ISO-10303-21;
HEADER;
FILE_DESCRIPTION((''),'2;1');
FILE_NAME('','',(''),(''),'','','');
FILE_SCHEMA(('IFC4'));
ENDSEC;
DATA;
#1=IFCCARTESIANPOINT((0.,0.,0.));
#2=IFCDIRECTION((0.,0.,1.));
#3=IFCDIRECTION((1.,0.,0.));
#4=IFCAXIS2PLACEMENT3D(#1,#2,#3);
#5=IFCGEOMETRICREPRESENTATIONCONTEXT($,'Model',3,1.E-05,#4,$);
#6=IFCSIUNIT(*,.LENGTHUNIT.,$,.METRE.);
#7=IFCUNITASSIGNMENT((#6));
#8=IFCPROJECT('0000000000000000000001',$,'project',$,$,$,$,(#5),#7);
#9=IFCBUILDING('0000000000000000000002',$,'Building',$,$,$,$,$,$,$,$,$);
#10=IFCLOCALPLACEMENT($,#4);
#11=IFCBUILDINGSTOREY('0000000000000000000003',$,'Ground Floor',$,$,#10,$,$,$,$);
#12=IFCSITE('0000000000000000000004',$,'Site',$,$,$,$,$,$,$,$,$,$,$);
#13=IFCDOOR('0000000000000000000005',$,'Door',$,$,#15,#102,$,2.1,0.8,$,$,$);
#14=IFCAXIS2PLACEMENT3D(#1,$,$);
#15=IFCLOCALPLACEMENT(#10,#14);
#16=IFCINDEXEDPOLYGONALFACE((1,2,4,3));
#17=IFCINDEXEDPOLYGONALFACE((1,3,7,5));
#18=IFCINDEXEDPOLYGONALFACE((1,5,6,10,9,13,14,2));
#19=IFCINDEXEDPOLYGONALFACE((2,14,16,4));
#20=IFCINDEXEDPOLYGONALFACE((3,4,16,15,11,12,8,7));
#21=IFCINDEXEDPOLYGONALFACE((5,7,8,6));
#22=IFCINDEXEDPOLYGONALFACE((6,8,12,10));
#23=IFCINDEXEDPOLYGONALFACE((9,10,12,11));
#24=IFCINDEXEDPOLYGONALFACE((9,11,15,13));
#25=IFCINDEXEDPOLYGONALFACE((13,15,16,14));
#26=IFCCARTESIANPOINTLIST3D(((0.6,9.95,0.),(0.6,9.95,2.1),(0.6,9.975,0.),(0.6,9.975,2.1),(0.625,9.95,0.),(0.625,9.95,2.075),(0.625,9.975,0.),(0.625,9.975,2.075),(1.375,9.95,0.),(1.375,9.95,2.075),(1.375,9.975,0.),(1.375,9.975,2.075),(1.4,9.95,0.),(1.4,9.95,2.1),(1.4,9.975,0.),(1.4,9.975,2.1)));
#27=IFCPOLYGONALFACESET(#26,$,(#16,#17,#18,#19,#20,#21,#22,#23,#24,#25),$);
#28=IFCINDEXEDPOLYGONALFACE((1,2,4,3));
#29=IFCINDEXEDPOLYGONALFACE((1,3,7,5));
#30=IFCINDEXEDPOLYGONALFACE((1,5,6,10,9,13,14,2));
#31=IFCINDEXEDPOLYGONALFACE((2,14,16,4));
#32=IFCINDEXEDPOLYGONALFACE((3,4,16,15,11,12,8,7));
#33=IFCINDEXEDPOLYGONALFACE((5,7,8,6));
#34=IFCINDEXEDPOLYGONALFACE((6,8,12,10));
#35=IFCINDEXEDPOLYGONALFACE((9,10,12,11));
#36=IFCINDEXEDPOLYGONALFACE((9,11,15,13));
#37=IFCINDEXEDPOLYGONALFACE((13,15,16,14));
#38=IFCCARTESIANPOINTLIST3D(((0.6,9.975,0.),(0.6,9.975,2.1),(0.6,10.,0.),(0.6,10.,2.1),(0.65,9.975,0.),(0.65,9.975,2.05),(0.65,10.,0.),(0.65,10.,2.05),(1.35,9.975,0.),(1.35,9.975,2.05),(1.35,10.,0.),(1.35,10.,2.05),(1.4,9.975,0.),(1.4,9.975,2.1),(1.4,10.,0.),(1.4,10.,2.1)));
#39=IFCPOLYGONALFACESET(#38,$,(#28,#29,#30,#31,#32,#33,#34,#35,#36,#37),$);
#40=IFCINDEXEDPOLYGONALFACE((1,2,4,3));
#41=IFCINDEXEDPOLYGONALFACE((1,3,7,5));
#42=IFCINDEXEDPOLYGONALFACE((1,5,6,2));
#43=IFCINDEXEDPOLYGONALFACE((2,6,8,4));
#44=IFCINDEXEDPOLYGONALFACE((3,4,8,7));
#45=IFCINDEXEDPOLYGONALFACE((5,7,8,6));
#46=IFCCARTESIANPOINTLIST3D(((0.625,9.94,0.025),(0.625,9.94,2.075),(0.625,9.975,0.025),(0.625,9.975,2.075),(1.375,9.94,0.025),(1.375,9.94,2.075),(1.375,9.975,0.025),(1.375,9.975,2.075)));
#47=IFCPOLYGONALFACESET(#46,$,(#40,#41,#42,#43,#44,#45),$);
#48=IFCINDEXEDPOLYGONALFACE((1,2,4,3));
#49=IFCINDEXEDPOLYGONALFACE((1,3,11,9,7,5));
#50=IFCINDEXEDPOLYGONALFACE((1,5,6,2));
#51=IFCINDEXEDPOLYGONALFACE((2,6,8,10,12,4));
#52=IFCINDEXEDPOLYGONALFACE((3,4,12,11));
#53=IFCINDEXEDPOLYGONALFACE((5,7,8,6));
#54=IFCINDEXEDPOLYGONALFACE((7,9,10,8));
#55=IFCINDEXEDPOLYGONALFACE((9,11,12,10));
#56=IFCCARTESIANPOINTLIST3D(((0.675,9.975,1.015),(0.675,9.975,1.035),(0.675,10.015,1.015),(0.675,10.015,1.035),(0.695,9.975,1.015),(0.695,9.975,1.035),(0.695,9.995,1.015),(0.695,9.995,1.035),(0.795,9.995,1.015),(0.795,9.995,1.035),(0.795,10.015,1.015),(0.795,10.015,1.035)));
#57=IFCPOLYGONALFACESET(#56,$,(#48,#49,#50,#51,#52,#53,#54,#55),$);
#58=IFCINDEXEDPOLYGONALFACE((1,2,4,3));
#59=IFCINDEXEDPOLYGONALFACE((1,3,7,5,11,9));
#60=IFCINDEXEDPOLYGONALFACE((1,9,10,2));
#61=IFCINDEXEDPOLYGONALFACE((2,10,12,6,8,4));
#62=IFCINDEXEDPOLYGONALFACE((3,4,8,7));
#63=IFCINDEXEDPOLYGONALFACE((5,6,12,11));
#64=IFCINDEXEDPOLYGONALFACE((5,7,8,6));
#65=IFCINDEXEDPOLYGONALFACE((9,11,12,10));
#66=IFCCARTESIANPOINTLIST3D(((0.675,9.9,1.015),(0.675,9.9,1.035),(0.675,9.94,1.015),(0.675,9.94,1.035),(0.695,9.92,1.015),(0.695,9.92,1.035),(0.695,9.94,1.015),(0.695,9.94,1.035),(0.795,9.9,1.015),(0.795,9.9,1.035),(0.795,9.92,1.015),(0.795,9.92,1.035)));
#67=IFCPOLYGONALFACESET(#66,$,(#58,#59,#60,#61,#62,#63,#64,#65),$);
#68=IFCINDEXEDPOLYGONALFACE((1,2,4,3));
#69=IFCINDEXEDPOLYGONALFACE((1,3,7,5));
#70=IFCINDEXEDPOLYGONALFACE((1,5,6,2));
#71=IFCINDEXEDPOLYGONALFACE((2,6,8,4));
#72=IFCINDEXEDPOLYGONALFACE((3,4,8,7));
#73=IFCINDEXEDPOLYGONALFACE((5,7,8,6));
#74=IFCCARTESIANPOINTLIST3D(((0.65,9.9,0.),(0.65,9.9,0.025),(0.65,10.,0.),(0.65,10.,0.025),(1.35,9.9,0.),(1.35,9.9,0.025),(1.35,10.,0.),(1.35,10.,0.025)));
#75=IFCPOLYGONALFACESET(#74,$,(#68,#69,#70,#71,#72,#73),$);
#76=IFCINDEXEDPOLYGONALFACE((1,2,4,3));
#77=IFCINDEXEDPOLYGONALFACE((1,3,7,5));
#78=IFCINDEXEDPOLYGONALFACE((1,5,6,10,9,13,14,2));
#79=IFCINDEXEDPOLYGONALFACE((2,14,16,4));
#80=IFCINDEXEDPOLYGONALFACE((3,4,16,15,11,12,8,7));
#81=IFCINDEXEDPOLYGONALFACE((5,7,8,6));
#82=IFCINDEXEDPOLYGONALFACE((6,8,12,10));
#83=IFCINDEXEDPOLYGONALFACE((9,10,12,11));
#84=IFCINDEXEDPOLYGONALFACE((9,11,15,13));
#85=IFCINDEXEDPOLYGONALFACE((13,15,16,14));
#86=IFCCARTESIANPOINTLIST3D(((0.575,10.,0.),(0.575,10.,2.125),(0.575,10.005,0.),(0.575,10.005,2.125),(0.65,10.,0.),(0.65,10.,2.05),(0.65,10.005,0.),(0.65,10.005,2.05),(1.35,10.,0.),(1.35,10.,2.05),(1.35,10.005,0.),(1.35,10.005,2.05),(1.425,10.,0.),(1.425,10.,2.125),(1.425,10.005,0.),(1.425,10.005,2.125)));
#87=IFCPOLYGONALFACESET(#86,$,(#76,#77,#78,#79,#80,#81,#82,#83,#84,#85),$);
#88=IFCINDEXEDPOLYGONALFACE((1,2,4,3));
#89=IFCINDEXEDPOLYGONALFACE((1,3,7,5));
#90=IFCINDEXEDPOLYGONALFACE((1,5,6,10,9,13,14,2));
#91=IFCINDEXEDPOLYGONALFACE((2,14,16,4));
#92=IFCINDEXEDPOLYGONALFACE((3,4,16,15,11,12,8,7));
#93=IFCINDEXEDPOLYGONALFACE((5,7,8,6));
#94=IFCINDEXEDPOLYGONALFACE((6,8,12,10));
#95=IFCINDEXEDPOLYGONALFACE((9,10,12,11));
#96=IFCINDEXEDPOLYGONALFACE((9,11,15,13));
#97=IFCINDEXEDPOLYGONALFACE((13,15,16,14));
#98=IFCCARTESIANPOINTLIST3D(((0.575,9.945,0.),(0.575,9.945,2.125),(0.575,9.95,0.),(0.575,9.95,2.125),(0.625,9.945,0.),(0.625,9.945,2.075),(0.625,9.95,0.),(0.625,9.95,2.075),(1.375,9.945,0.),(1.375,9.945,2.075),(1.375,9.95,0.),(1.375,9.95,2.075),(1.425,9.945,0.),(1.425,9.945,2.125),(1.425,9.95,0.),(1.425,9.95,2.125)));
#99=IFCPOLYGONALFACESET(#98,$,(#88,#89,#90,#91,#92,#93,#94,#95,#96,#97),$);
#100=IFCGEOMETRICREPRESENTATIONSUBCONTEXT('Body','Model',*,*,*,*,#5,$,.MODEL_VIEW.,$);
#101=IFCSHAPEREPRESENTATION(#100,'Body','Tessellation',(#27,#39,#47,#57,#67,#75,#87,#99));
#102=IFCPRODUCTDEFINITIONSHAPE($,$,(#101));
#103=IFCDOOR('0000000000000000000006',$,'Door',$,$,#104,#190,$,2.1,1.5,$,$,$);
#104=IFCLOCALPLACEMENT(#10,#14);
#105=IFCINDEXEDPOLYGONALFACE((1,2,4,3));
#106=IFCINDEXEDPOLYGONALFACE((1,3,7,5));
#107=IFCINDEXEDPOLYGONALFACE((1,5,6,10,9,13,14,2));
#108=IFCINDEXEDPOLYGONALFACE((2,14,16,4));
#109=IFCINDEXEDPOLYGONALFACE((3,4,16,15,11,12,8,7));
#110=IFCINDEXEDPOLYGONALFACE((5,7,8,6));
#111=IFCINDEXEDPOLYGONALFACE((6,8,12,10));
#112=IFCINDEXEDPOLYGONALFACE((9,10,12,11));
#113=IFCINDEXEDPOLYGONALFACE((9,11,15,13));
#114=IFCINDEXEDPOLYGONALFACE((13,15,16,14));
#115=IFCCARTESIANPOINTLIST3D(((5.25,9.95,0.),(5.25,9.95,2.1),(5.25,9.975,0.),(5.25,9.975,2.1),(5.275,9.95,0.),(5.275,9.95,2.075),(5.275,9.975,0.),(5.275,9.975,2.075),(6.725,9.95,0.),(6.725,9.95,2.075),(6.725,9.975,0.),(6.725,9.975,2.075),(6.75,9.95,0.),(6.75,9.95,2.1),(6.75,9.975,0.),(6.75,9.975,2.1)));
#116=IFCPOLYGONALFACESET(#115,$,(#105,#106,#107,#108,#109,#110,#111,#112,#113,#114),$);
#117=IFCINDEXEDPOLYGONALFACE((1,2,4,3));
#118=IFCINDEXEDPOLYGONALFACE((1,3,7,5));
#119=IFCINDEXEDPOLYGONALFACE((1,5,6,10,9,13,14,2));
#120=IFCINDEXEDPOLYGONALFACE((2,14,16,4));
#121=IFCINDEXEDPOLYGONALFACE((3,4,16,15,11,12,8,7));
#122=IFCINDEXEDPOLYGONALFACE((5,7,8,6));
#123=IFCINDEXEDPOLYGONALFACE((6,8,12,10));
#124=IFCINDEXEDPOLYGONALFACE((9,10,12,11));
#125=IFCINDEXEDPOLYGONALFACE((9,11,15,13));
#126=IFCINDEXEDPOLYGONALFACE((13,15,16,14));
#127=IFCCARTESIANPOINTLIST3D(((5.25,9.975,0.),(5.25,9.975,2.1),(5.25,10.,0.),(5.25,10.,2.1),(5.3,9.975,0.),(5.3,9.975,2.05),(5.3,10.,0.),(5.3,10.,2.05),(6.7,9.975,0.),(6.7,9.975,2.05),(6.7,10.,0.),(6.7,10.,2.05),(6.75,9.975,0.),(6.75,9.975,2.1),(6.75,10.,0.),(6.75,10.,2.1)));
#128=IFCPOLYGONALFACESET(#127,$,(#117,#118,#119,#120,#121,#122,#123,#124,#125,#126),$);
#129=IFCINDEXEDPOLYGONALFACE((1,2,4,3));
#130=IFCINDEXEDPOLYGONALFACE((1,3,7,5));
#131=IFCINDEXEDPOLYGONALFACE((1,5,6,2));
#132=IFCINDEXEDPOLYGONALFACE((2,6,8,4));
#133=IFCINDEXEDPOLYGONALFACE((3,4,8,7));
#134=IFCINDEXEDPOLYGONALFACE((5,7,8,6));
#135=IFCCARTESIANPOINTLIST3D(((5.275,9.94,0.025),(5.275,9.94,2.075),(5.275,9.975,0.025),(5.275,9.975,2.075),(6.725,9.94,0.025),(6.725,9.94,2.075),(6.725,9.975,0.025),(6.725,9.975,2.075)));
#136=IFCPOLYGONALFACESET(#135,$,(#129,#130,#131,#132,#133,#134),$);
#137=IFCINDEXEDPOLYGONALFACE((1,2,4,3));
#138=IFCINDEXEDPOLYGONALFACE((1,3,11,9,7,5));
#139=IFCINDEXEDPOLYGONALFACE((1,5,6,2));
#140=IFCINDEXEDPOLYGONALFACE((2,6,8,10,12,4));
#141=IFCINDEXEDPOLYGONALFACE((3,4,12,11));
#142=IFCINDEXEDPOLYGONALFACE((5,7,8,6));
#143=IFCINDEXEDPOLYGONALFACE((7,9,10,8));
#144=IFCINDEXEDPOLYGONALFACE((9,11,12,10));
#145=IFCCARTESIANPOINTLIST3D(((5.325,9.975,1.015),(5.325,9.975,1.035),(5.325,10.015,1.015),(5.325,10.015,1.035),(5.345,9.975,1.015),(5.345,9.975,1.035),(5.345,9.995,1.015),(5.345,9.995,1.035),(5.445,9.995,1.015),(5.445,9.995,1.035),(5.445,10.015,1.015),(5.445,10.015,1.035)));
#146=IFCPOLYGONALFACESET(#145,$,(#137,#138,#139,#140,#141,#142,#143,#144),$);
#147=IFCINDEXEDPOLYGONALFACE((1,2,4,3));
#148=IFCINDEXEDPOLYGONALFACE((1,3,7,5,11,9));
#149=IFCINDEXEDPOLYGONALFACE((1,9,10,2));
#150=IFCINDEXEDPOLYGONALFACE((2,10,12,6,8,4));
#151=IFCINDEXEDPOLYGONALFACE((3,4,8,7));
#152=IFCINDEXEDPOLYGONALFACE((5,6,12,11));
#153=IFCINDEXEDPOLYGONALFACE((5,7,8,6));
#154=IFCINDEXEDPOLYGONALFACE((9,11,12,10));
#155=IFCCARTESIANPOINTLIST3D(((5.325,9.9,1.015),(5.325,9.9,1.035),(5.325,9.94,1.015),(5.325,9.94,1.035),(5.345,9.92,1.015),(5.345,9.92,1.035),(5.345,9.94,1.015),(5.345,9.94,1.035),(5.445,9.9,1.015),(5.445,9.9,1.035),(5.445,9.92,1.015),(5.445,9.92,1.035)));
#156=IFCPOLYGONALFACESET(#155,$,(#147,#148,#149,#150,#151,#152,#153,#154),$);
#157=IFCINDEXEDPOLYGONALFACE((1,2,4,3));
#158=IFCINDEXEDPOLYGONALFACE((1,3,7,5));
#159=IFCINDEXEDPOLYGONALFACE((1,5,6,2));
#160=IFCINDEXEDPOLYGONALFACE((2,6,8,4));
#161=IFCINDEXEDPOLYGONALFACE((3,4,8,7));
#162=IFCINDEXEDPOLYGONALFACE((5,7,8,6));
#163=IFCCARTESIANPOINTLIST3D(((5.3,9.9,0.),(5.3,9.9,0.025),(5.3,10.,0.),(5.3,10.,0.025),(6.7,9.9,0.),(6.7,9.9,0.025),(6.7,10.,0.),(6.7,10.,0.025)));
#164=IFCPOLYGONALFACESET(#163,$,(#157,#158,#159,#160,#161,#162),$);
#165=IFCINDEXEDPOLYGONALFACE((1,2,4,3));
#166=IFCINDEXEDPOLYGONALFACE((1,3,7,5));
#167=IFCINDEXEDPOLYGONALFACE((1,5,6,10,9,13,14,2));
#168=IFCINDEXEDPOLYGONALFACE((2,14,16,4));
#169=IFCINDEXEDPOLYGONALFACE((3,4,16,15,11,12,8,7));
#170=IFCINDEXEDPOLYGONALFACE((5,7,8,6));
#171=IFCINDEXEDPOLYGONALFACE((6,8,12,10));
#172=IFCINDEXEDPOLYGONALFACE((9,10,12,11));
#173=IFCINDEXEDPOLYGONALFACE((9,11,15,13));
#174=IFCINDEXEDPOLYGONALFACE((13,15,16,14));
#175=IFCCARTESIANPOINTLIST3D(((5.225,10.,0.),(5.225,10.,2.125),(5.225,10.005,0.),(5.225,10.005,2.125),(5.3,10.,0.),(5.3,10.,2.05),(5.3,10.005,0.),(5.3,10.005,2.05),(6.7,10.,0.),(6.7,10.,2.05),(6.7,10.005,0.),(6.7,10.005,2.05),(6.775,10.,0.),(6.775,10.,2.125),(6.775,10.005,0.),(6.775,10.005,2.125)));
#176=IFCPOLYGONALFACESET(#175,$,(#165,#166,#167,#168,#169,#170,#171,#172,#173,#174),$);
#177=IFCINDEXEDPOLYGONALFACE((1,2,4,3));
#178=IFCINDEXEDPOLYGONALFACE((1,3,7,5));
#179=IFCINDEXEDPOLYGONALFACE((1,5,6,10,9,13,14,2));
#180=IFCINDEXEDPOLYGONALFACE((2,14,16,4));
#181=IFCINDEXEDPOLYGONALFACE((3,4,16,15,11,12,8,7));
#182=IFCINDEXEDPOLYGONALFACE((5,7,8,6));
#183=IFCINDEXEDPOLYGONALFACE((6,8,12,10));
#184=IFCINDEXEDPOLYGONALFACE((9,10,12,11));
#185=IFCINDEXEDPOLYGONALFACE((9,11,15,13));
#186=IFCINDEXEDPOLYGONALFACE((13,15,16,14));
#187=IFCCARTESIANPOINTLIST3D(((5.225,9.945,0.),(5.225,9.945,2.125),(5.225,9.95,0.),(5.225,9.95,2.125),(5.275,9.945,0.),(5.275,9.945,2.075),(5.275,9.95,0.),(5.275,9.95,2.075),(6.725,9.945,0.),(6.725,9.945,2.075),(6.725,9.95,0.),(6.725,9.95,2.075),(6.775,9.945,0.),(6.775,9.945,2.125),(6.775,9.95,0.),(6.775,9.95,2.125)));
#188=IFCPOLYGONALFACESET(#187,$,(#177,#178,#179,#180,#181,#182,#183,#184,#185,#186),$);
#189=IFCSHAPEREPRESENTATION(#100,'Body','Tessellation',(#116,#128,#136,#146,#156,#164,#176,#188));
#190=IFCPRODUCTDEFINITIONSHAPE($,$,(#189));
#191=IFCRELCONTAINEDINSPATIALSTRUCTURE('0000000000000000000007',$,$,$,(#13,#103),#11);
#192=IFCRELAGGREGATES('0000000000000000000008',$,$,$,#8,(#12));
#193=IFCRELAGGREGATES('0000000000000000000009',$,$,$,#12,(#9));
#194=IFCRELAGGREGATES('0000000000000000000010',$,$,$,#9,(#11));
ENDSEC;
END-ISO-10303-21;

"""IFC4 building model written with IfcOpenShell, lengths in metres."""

from ifc_helpers import new_model, si_unit, frame, origin_with_axes, place, context, subcontext, project, spatial, line, indexed_curve, outline, extrude, element, save


model = new_model("IFC4")

# Units and contexts
model_context = context("Model", 3, precision=1e-05, world=origin_with_axes())
body_context = subcontext(model_context, "Body", "Model", "MODEL_VIEW")
ifc_project = project(units=[si_unit("LENGTHUNIT", "METRE")], contexts=[model_context])

# Site, building, storey
site = spatial("IfcSite", under=ifc_project, Name="Site")
building = spatial("IfcBuilding", under=site, Name="Building")
storey_placement = place(None, origin_with_axes())
storey = spatial("IfcBuildingStorey", under=building, at=storey_placement, Name="Ground Floor")

# Doors
door_1_placement = place(storey_placement, frame((1.4, 10.0, 0.0), z_axis=(0.0, 0.0, 1.0), x_axis=(-1.0, 0.0, 0.0)))
element("IfcDoor", 1, at=door_1_placement, inside=storey, Name="Door", OverallHeight=2.1, OverallWidth=0.8, context=body_context, shape_type="SweptSolid", body=[
    extrude(outline(indexed_curve([(0.0, 0.0), (0.0, 2.1), (0.8, 2.1), (0.8, 0.0), (0.775, 0.0), (0.775, 2.075), (0.025, 2.075), (0.025, 0.0)], segments=[line(1, 2, 3, 4, 5, 6, 7, 8, 1)])), frame((0.0, 0.025, 0.0), z_axis=(0.0, -1.0, 0.0), x_axis=(1.0, 0.0, 0.0)), (0.0, 0.0, -1.0), 0.025),
    extrude(outline(indexed_curve([(0.0, 0.0), (0.0, 2.1), (0.8, 2.1), (0.8, 0.0), (0.75, 0.0), (0.75, 2.05), (0.05, 2.05), (0.05, 0.0)], segments=[line(1, 2, 3, 4, 5, 6, 7, 8, 1)])), frame((0.0, 0.0, 0.0), z_axis=(0.0, -1.0, 0.0), x_axis=(1.0, 0.0, 0.0)), (0.0, 0.0, -1.0), 0.025),
    extrude(outline(indexed_curve([(0.0, 0.0), (0.75, 0.0), (0.75, 0.035), (0.0, 0.035)], segments=[line(1, 2, 3, 4, 1)])), frame((0.025, 0.025, 0.025), z_axis=(0.0, 0.0, 1.0), x_axis=(1.0, 0.0, 0.0)), (0.0, 0.0, 1.0), 2.05),
    extrude(outline(indexed_curve([(0.0, 0.0), (0.0, -0.04), (-0.12, -0.04), (-0.12, -0.02), (-0.02, -0.02), (-0.02, 0.0)], segments=[line(1, 2, 3, 4, 5, 6, 1)])), frame((0.725, 0.025, 1.015), z_axis=(0.0, 0.0, 1.0), x_axis=(1.0, 0.0, 0.0)), (0.0, 0.0, 1.0), 0.02),
    extrude(outline(indexed_curve([(0.0, 0.0), (0.0, 0.04), (-0.12, 0.04), (-0.12, 0.02), (-0.02, 0.02), (-0.02, 0.0)], segments=[line(1, 2, 3, 4, 5, 6, 1)])), frame((0.725, 0.06, 1.015), z_axis=(0.0, 0.0, 1.0), x_axis=(1.0, 0.0, 0.0)), (0.0, 0.0, 1.0), 0.02),
    extrude(outline(indexed_curve([(0.0, 0.0), (0.7, 0.0), (0.7, 0.1), (0.0, 0.1)], segments=[line(1, 2, 3, 4, 1)])), frame((0.05, 0.0, 0.0), z_axis=(0.0, 0.0, 1.0), x_axis=(1.0, 0.0, 0.0)), (0.0, 0.0, 1.0), 0.025),
    extrude(outline(indexed_curve([(0.0, 0.0), (0.0, 2.125), (0.85, 2.125), (0.85, 0.0), (0.775, 0.0), (0.775, 2.05), (0.075, 2.05), (0.075, 0.0)], segments=[line(1, 2, 3, 4, 5, 6, 7, 8, 1)])), frame((-0.025, -0.005, 0.0), z_axis=(0.0, -1.0, 0.0), x_axis=(1.0, 0.0, 0.0)), (0.0, 0.0, -1.0), 0.005),
    extrude(outline(indexed_curve([(0.0, 0.0), (0.0, 2.125), (0.85, 2.125), (0.85, 0.0), (0.8, 0.0), (0.8, 2.075), (0.05, 2.075), (0.05, 0.0)], segments=[line(1, 2, 3, 4, 5, 6, 7, 8, 1)])), frame((-0.025, 0.05, 0.0), z_axis=(0.0, -1.0, 0.0), x_axis=(1.0, 0.0, 0.0)), (0.0, 0.0, -1.0), 0.005),
])
door_2_placement = place(storey_placement, frame((6.75, 10.0, 0.0), z_axis=(0.0, 0.0, 1.0), x_axis=(-1.0, 0.0, 0.0)))
element("IfcDoor", 2, at=door_2_placement, inside=storey, Name="Door", OverallHeight=2.1, OverallWidth=1.5, context=body_context, shape_type="SweptSolid", body=[
    extrude(outline(indexed_curve([(0.0, 0.0), (0.0, 2.1), (1.5, 2.1), (1.5, 0.0), (1.475, 0.0), (1.475, 2.075), (0.025, 2.075), (0.025, 0.0)], segments=[line(1, 2, 3, 4, 5, 6, 7, 8, 1)])), frame((0.0, 0.025, 0.0), z_axis=(0.0, -1.0, 0.0), x_axis=(1.0, 0.0, 0.0)), (0.0, 0.0, -1.0), 0.025),
    extrude(outline(indexed_curve([(0.0, 0.0), (0.0, 2.1), (1.5, 2.1), (1.5, 0.0), (1.45, 0.0), (1.45, 2.05), (0.05, 2.05), (0.05, 0.0)], segments=[line(1, 2, 3, 4, 5, 6, 7, 8, 1)])), frame((0.0, 0.0, 0.0), z_axis=(0.0, -1.0, 0.0), x_axis=(1.0, 0.0, 0.0)), (0.0, 0.0, -1.0), 0.025),
    extrude(outline(indexed_curve([(0.0, 0.0), (1.45, 0.0), (1.45, 0.035), (0.0, 0.035)], segments=[line(1, 2, 3, 4, 1)])), frame((0.025, 0.025, 0.025), z_axis=(0.0, 0.0, 1.0), x_axis=(1.0, 0.0, 0.0)), (0.0, 0.0, 1.0), 2.05),
    extrude(outline(indexed_curve([(0.0, 0.0), (0.0, -0.04), (-0.12, -0.04), (-0.12, -0.02), (-0.02, -0.02), (-0.02, 0.0)], segments=[line(1, 2, 3, 4, 5, 6, 1)])), frame((1.425, 0.025, 1.015), z_axis=(0.0, 0.0, 1.0), x_axis=(1.0, 0.0, 0.0)), (0.0, 0.0, 1.0), 0.02),
    extrude(outline(indexed_curve([(0.0, 0.0), (0.0, 0.04), (-0.12, 0.04), (-0.12, 0.02), (-0.02, 0.02), (-0.02, 0.0)], segments=[line(1, 2, 3, 4, 5, 6, 1)])), frame((1.425, 0.06, 1.015), z_axis=(0.0, 0.0, 1.0), x_axis=(1.0, 0.0, 0.0)), (0.0, 0.0, 1.0), 0.02),
    extrude(outline(indexed_curve([(0.0, 0.0), (1.4, 0.0), (1.4, 0.1), (0.0, 0.1)], segments=[line(1, 2, 3, 4, 1)])), frame((0.05, 0.0, 0.0), z_axis=(0.0, 0.0, 1.0), x_axis=(1.0, 0.0, 0.0)), (0.0, 0.0, 1.0), 0.025),
    extrude(outline(indexed_curve([(0.0, 0.0), (0.0, 2.125), (1.55, 2.125), (1.55, 0.0), (1.475, 0.0), (1.475, 2.05), (0.075, 2.05), (0.075, 0.0)], segments=[line(1, 2, 3, 4, 5, 6, 7, 8, 1)])), frame((-0.025, -0.005, 0.0), z_axis=(0.0, -1.0, 0.0), x_axis=(1.0, 0.0, 0.0)), (0.0, 0.0, -1.0), 0.005),
    extrude(outline(indexed_curve([(0.0, 0.0), (0.0, 2.125), (1.55, 2.125), (1.55, 0.0), (1.5, 0.0), (1.5, 2.075), (0.05, 2.075), (0.05, 0.0)], segments=[line(1, 2, 3, 4, 5, 6, 7, 8, 1)])), frame((-0.025, 0.05, 0.0), z_axis=(0.0, -1.0, 0.0), x_axis=(1.0, 0.0, 0.0)), (0.0, 0.0, -1.0), 0.005),
])

save(model, "model.ifc")
